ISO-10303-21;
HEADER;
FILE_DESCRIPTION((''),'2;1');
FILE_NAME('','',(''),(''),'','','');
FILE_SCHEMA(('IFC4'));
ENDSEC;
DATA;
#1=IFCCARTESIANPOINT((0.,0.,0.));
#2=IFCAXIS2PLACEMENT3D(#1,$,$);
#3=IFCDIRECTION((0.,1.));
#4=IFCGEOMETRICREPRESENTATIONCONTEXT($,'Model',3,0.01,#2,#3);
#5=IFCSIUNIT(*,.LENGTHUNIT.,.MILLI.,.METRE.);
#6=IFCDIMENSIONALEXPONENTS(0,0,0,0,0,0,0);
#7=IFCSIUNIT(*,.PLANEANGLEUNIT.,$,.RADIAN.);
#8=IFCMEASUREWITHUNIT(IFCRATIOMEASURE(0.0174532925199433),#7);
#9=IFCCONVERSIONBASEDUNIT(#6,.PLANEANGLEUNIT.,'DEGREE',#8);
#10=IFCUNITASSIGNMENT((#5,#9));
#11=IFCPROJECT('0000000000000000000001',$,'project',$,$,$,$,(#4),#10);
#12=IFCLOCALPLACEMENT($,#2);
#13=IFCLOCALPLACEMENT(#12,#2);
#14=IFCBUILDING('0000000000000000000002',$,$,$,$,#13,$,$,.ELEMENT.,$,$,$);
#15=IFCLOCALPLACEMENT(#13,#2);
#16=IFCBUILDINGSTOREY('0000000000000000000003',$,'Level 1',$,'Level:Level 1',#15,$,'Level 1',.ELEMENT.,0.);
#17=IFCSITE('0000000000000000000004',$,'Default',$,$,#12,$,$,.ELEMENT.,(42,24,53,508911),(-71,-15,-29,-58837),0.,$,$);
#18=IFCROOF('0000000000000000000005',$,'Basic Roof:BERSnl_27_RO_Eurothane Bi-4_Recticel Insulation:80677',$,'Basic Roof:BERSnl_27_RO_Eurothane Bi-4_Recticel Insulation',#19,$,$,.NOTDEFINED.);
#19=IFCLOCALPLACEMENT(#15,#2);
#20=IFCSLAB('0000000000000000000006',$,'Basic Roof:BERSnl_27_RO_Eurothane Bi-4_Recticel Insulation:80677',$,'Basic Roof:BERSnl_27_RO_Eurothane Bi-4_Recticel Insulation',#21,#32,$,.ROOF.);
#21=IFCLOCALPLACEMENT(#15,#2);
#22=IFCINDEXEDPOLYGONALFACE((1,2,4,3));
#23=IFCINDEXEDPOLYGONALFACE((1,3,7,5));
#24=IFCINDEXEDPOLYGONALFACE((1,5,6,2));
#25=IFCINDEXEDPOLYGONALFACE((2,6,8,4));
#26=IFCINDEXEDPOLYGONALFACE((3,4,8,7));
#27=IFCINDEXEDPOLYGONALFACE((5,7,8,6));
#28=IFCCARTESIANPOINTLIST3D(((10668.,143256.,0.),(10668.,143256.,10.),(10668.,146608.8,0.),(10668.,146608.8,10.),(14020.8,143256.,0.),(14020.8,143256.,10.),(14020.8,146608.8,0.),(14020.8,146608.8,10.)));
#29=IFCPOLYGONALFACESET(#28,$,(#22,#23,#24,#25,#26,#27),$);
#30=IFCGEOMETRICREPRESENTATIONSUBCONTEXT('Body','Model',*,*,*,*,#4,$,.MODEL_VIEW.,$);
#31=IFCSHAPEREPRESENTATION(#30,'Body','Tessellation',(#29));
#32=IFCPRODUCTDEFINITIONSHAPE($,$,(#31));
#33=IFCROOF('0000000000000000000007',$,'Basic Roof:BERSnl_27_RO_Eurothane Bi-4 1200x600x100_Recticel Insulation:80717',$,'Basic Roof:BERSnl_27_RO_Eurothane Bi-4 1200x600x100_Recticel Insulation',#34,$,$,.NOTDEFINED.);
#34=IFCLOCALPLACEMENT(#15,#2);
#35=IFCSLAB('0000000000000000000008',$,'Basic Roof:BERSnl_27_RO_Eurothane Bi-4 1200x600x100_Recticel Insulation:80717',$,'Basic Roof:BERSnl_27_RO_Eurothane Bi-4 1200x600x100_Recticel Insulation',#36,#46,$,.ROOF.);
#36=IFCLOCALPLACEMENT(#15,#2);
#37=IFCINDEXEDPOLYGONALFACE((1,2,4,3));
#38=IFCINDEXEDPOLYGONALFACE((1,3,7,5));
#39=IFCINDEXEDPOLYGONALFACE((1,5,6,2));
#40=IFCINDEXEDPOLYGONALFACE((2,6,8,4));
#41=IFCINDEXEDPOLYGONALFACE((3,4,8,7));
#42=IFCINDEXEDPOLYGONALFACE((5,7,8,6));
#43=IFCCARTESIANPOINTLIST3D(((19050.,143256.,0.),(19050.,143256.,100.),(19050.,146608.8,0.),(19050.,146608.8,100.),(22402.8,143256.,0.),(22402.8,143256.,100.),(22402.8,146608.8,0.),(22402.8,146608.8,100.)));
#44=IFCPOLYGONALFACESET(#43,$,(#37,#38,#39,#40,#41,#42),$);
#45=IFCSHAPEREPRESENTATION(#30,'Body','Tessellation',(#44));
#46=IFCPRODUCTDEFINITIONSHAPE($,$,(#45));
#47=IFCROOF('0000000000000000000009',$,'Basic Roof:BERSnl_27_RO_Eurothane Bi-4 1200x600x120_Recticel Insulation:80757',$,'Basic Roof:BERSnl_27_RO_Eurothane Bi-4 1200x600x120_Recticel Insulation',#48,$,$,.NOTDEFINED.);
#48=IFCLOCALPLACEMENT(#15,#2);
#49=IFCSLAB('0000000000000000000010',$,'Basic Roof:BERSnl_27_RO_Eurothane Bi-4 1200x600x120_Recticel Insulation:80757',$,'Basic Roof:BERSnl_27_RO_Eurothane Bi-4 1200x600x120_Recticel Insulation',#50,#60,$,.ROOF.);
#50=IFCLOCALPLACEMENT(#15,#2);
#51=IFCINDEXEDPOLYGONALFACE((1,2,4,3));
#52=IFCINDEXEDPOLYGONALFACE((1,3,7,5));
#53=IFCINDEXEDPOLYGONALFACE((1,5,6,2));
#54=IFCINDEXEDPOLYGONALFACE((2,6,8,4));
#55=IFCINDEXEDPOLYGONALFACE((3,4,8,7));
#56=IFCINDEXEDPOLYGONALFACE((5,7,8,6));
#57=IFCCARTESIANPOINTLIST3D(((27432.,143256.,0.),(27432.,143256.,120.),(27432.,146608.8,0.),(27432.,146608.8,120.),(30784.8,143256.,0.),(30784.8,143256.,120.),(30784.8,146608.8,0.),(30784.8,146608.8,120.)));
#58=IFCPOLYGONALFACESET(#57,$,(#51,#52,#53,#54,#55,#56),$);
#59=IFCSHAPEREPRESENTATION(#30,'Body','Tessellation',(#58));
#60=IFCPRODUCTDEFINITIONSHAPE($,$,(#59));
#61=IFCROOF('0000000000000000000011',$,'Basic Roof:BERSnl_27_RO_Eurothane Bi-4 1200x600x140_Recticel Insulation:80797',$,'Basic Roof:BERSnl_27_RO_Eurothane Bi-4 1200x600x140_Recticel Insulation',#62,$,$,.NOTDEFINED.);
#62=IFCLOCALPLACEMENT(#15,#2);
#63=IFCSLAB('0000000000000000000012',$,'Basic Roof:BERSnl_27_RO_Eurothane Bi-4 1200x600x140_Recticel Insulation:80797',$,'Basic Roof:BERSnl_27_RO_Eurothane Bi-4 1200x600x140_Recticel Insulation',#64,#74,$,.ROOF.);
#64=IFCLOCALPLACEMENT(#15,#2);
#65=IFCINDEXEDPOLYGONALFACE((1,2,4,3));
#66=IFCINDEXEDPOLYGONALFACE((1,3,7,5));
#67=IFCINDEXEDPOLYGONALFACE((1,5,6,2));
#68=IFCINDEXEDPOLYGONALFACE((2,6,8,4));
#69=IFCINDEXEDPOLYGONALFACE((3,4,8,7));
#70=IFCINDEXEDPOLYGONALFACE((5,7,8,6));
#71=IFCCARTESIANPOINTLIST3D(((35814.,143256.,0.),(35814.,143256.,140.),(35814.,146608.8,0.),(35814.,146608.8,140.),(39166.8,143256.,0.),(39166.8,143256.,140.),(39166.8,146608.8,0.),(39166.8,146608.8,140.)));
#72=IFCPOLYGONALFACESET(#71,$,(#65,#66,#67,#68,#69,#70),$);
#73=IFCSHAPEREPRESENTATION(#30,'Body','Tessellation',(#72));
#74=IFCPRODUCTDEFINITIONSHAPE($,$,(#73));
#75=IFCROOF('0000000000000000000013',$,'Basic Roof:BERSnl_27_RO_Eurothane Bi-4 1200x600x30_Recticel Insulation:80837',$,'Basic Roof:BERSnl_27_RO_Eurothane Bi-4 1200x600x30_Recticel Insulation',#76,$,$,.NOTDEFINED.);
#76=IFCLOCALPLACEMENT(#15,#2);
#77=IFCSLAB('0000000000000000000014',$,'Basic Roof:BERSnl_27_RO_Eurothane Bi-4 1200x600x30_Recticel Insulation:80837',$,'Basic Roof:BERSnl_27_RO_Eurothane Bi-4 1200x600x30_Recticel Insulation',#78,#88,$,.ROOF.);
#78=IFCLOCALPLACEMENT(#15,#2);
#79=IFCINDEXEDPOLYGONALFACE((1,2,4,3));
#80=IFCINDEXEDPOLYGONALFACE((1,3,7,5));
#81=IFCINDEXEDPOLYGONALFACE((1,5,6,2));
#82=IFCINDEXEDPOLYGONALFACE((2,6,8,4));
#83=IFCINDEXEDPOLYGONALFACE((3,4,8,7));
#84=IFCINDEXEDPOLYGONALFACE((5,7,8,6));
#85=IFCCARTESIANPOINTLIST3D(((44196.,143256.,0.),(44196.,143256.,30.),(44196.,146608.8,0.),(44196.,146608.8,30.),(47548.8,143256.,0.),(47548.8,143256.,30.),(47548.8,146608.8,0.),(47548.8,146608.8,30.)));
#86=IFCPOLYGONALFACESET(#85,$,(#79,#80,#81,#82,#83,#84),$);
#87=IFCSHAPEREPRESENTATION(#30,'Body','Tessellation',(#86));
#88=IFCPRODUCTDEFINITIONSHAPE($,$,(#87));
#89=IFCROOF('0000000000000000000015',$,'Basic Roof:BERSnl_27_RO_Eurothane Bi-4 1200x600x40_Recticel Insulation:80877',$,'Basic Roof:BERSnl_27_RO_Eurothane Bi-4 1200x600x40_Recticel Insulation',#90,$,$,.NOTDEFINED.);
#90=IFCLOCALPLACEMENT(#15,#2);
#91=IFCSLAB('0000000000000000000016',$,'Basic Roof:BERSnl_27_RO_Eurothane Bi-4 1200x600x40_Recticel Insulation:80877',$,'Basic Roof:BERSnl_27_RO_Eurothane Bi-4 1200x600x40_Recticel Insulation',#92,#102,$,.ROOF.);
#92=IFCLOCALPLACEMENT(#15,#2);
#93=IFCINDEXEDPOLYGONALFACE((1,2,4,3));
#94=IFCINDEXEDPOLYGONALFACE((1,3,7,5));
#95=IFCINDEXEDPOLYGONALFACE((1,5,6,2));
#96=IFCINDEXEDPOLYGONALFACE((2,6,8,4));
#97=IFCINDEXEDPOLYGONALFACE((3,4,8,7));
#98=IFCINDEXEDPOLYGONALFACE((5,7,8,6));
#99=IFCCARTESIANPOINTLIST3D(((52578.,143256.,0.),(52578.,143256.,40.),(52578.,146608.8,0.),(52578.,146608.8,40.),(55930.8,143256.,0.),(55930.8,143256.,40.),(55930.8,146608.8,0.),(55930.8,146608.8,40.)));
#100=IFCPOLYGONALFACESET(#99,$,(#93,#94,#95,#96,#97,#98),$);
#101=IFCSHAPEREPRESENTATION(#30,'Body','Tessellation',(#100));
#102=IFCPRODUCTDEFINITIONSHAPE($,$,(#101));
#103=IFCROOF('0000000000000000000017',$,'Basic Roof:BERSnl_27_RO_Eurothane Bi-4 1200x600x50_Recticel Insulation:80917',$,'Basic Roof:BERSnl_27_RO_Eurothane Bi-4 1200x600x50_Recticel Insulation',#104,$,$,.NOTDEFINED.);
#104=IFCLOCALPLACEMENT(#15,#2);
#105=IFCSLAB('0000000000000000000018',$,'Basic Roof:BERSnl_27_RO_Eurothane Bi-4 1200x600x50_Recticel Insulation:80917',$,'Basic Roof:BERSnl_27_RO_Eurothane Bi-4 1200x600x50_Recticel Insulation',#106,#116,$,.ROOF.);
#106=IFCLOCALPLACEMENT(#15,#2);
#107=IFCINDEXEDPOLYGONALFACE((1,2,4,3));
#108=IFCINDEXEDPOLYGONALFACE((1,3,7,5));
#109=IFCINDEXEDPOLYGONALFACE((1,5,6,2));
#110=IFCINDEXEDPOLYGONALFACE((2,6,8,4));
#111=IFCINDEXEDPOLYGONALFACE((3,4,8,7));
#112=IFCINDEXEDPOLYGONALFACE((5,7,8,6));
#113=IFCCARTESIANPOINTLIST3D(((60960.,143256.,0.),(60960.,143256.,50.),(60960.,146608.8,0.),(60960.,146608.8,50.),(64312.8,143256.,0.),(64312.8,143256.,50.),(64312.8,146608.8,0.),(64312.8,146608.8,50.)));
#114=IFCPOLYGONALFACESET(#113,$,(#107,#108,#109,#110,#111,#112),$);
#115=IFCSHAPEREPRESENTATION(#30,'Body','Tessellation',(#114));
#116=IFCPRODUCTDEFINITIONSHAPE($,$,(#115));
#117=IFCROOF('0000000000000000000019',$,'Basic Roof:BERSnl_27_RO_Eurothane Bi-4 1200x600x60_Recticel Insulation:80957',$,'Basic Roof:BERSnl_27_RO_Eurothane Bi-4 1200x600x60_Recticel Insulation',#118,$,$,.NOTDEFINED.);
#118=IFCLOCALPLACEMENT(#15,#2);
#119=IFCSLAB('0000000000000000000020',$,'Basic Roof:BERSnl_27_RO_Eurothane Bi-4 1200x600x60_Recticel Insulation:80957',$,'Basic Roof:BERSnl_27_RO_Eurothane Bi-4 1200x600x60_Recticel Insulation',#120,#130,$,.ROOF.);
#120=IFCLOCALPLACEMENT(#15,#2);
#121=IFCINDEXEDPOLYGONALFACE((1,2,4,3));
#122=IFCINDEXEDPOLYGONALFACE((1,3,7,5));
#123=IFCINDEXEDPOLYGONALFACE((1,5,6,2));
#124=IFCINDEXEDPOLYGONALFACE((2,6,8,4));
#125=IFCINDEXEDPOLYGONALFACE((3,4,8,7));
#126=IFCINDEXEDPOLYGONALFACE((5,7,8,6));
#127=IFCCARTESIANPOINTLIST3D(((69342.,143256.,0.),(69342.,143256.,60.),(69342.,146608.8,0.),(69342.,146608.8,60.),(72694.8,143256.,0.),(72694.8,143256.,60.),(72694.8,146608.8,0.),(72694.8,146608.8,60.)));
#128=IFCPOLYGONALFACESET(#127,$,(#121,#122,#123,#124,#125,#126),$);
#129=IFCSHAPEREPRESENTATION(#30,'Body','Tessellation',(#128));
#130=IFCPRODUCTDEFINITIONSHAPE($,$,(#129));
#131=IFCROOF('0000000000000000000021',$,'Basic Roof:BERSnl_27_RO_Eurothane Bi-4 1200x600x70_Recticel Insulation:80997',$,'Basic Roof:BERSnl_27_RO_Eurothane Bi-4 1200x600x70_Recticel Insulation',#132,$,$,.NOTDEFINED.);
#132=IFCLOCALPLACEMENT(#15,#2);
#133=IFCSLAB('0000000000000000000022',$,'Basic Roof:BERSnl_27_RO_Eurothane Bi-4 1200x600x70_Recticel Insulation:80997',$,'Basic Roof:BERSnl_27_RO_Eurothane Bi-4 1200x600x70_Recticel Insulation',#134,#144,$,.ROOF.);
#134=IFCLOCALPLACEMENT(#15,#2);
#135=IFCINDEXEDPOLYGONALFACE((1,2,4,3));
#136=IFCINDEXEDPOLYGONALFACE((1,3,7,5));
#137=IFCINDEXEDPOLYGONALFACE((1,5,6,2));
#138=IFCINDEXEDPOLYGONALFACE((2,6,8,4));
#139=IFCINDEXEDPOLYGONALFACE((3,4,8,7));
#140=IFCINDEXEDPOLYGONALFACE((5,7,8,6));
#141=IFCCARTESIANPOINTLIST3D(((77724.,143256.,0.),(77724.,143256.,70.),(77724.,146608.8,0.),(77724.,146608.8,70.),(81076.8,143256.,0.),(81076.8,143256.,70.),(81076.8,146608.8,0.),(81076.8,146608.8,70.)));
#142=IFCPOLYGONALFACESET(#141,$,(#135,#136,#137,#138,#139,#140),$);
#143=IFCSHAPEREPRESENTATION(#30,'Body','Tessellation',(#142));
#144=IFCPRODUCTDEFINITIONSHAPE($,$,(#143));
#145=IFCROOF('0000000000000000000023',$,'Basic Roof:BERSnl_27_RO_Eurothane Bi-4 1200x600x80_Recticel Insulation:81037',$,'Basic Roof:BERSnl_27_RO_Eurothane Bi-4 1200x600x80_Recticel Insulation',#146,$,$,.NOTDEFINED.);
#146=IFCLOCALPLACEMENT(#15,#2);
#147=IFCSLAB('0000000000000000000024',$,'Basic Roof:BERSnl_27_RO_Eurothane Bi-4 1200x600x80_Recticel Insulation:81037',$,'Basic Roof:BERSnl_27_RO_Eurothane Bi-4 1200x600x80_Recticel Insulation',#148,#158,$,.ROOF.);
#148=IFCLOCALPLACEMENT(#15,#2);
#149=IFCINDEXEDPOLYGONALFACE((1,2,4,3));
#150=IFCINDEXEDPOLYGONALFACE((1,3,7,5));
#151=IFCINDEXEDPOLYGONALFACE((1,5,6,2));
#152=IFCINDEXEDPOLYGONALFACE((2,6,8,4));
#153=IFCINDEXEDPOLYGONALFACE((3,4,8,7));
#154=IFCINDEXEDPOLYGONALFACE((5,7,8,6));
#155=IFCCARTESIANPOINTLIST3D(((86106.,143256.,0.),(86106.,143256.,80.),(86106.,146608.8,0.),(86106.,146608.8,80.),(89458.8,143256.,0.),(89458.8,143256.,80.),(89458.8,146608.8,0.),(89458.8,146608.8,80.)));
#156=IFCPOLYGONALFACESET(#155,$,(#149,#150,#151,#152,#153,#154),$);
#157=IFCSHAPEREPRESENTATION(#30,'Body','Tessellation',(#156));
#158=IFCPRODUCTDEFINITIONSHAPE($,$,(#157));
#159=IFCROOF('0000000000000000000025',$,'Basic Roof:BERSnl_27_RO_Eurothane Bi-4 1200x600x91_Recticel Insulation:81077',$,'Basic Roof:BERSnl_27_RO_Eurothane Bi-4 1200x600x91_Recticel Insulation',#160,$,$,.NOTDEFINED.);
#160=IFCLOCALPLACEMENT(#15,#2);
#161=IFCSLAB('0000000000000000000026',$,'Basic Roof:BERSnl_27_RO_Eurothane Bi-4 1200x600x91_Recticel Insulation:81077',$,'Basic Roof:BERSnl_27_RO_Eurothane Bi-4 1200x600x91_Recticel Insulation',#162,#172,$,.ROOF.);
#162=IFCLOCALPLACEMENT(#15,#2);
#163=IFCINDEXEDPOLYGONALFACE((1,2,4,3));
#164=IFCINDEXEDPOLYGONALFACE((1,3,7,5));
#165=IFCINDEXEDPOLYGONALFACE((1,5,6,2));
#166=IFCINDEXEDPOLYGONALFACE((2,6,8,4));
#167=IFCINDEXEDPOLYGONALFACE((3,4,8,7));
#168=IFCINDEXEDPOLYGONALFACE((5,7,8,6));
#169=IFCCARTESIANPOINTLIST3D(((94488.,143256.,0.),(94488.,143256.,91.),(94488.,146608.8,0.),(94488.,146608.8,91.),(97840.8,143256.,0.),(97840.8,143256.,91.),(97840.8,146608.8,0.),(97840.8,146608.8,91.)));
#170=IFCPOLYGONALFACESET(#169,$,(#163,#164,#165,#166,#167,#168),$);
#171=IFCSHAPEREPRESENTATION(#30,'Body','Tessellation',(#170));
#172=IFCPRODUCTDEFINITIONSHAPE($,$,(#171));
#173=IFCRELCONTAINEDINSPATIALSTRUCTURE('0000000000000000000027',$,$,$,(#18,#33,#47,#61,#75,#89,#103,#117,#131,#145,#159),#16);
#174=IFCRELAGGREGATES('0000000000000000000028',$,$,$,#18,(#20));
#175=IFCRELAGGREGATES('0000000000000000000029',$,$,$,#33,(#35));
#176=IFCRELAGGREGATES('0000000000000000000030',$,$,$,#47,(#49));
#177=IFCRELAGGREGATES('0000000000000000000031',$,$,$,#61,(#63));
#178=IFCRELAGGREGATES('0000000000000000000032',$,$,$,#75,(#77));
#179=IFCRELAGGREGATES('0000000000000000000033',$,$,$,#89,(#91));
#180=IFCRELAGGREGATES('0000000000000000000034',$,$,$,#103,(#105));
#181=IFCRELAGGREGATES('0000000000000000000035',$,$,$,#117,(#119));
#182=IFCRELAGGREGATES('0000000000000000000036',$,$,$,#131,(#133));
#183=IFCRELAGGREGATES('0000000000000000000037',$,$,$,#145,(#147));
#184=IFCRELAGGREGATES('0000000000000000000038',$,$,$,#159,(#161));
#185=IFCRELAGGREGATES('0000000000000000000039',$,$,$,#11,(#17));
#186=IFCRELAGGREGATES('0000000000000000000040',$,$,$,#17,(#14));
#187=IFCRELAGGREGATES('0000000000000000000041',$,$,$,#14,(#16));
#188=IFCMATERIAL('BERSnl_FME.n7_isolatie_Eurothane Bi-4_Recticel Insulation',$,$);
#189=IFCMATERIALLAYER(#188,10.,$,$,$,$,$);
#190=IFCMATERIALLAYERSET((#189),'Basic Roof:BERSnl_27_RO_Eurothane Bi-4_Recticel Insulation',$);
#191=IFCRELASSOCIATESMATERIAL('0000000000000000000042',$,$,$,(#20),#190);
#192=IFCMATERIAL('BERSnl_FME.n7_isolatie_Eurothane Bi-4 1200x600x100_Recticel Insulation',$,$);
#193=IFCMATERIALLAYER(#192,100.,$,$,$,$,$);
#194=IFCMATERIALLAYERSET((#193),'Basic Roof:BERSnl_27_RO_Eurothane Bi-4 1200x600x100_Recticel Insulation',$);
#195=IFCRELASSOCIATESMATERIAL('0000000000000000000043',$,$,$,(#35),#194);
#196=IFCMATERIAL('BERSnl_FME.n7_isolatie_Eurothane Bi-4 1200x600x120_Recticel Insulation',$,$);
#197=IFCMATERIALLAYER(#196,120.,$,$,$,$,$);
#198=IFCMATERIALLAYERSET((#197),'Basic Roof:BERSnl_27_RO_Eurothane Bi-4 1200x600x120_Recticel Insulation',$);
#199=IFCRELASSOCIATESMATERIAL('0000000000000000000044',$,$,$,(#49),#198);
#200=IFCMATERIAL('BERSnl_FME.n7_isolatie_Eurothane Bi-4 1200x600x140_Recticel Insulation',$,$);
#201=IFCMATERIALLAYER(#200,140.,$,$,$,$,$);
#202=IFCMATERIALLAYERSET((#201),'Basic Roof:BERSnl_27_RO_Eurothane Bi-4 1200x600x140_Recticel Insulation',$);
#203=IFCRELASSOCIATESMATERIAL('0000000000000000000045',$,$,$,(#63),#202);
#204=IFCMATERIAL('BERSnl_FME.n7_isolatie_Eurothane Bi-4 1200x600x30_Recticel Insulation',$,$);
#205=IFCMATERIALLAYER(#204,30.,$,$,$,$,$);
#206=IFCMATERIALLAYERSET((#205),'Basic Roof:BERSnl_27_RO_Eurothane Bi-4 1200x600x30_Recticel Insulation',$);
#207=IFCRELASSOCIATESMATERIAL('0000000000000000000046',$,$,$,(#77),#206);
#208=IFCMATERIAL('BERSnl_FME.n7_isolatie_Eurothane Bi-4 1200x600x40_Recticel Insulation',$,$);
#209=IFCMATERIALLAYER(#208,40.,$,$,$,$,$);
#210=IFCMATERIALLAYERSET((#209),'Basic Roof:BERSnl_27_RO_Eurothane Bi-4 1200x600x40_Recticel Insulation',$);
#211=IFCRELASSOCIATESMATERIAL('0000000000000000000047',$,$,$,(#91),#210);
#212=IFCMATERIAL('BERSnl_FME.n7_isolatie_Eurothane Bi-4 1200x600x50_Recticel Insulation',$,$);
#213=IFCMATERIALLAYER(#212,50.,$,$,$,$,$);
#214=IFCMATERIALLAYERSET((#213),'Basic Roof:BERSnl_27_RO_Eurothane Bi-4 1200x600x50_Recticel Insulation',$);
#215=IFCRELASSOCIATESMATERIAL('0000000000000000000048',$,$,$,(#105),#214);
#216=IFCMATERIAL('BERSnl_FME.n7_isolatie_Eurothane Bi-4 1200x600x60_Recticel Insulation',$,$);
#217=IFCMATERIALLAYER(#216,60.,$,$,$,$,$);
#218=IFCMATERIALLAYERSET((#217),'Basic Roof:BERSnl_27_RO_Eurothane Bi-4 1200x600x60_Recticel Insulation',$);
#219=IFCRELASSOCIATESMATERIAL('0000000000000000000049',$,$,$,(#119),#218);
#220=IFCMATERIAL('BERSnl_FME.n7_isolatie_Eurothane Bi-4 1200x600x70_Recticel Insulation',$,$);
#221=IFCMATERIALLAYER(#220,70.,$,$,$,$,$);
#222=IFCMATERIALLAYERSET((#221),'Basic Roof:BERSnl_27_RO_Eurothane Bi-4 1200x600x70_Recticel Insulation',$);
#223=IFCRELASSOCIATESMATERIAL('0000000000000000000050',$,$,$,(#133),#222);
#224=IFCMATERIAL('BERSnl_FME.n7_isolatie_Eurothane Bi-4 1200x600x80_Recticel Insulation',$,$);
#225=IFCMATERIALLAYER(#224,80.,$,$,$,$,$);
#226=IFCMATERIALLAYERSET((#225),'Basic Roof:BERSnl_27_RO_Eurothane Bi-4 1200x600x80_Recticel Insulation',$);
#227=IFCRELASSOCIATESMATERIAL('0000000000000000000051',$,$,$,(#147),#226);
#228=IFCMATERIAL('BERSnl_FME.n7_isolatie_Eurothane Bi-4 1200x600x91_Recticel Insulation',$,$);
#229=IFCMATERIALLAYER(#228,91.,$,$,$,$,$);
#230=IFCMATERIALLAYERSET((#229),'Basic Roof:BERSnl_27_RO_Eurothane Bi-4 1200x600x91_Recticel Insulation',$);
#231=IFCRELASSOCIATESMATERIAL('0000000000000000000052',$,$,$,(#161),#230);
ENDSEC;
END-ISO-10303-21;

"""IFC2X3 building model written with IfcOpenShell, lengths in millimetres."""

from ifc_helpers import new_model, entity, si_unit, converted_unit, direction, frame, frame_2d, origin, place, context, subcontext, project, spatial, rectangle, extrude, material, layer, layer_set, element, aggregate, save


model = new_model("IFC2X3")

# Units and contexts
model_context = context("Model", 3, precision=0.01, world=origin(), true_north=direction((0.0, 1.0)))
body_context = subcontext(model_context, "Body", "Model", "MODEL_VIEW")
ifc_project = project(units=[si_unit("LENGTHUNIT", "METRE", prefix="MILLI"), converted_unit("PLANEANGLEUNIT", "DEGREE", entity("IfcRatioMeasure", 0.0174532925199433), si_unit("PLANEANGLEUNIT", "RADIAN"), dimensions=[0, 0, 0, 0, 0, 0, 0])], contexts=[model_context])

# Site, building, storey
site_placement = place(None, origin())
site = spatial("IfcSite", under=ifc_project, at=site_placement, Name="Default", CompositionType="ELEMENT", RefLatitude=(42, 24, 53, 508911), RefLongitude=(-71, -15, -29, -58837), RefElevation=0.0)
building_placement = place(site_placement, origin())
building = spatial("IfcBuilding", under=site, at=building_placement, CompositionType="ELEMENT")
storey_placement = place(building_placement, origin())
storey = spatial("IfcBuildingStorey", under=building, at=storey_placement, Name="Level 1", ObjectType="Level:Level 1", LongName="Level 1", CompositionType="ELEMENT", Elevation=0.0)

# Roofs, slabs
roof_1_placement = place(storey_placement, frame((10668.0, 143256.0, 0.0)))
roof_1 = element("IfcRoof", 1, at=roof_1_placement, inside=storey, Name="Basic Roof:BERSnl_27_RO_Eurothane Bi-4_Recticel Insulation:80677", ObjectType="Basic Roof:BERSnl_27_RO_Eurothane Bi-4_Recticel Insulation", ShapeType="NOTDEFINED")
ifc_material_1 = material(Name="BERSnl_FME.n7_isolatie_Eurothane Bi-4_Recticel Insulation")
ifc_layer_1 = layer(ifc_material_1, 10.0)
ifc_layer_set_1 = layer_set([ifc_layer_1], Name="Basic Roof:BERSnl_27_RO_Eurothane Bi-4_Recticel Insulation")
slab_1_placement = place(roof_1_placement, origin())
slab_1 = element("IfcSlab", 2, at=slab_1_placement, material=ifc_layer_set_1, Name="Basic Roof:BERSnl_27_RO_Eurothane Bi-4_Recticel Insulation:80677", ObjectType="Basic Roof:BERSnl_27_RO_Eurothane Bi-4_Recticel Insulation", PredefinedType="ROOF", context=body_context, shape_type="SweptSolid", body=[
    extrude(rectangle(XDim=3352.8, YDim=3352.8, at=frame_2d((0.0, 0.0), x_axis=(-1.0, 0.0))), frame((1676.4, 1676.4, 0.0)), (0.0, 0.0, 1.0), 10.0),
])
aggregate(roof_1, [slab_1])
roof_2_placement = place(storey_placement, frame((19050.0, 143256.0, 0.0)))
roof_2 = element("IfcRoof", 3, at=roof_2_placement, inside=storey, Name="Basic Roof:BERSnl_27_RO_Eurothane Bi-4 1200x600x100_Recticel Insulation:80717", ObjectType="Basic Roof:BERSnl_27_RO_Eurothane Bi-4 1200x600x100_Recticel Insulation", ShapeType="NOTDEFINED")
ifc_material_2 = material(Name="BERSnl_FME.n7_isolatie_Eurothane Bi-4 1200x600x100_Recticel Insulation")
ifc_layer_2 = layer(ifc_material_2, 100.0)
ifc_layer_set_2 = layer_set([ifc_layer_2], Name="Basic Roof:BERSnl_27_RO_Eurothane Bi-4 1200x600x100_Recticel Insulation")
slab_2_placement = place(roof_2_placement, origin())
slab_2 = element("IfcSlab", 4, at=slab_2_placement, material=ifc_layer_set_2, Name="Basic Roof:BERSnl_27_RO_Eurothane Bi-4 1200x600x100_Recticel Insulation:80717", ObjectType="Basic Roof:BERSnl_27_RO_Eurothane Bi-4 1200x600x100_Recticel Insulation", PredefinedType="ROOF", context=body_context, shape_type="SweptSolid", body=[
    extrude(rectangle(XDim=3352.8, YDim=3352.8, at=frame_2d((0.0, 0.0), x_axis=(-1.0, 0.0))), frame((1676.4, 1676.4, 0.0)), (0.0, 0.0, 1.0), 100.0),
])
aggregate(roof_2, [slab_2])
roof_3_placement = place(storey_placement, frame((27432.0, 143256.0, 0.0)))
roof_3 = element("IfcRoof", 5, at=roof_3_placement, inside=storey, Name="Basic Roof:BERSnl_27_RO_Eurothane Bi-4 1200x600x120_Recticel Insulation:80757", ObjectType="Basic Roof:BERSnl_27_RO_Eurothane Bi-4 1200x600x120_Recticel Insulation", ShapeType="NOTDEFINED")
ifc_material_3 = material(Name="BERSnl_FME.n7_isolatie_Eurothane Bi-4 1200x600x120_Recticel Insulation")
ifc_layer_3 = layer(ifc_material_3, 120.0)
ifc_layer_set_3 = layer_set([ifc_layer_3], Name="Basic Roof:BERSnl_27_RO_Eurothane Bi-4 1200x600x120_Recticel Insulation")
slab_3_placement = place(roof_3_placement, origin())
slab_3 = element("IfcSlab", 6, at=slab_3_placement, material=ifc_layer_set_3, Name="Basic Roof:BERSnl_27_RO_Eurothane Bi-4 1200x600x120_Recticel Insulation:80757", ObjectType="Basic Roof:BERSnl_27_RO_Eurothane Bi-4 1200x600x120_Recticel Insulation", PredefinedType="ROOF", context=body_context, shape_type="SweptSolid", body=[
    extrude(rectangle(XDim=3352.8, YDim=3352.8, at=frame_2d((0.0, 0.0), x_axis=(-1.0, 0.0))), frame((1676.4, 1676.4, 0.0)), (0.0, 0.0, 1.0), 120.0),
])
aggregate(roof_3, [slab_3])
roof_4_placement = place(storey_placement, frame((35814.0, 143256.0, 0.0)))
roof_4 = element("IfcRoof", 7, at=roof_4_placement, inside=storey, Name="Basic Roof:BERSnl_27_RO_Eurothane Bi-4 1200x600x140_Recticel Insulation:80797", ObjectType="Basic Roof:BERSnl_27_RO_Eurothane Bi-4 1200x600x140_Recticel Insulation", ShapeType="NOTDEFINED")
ifc_material_4 = material(Name="BERSnl_FME.n7_isolatie_Eurothane Bi-4 1200x600x140_Recticel Insulation")
ifc_layer_4 = layer(ifc_material_4, 140.0)
ifc_layer_set_4 = layer_set([ifc_layer_4], Name="Basic Roof:BERSnl_27_RO_Eurothane Bi-4 1200x600x140_Recticel Insulation")
slab_4_placement = place(roof_4_placement, origin())
slab_4 = element("IfcSlab", 8, at=slab_4_placement, material=ifc_layer_set_4, Name="Basic Roof:BERSnl_27_RO_Eurothane Bi-4 1200x600x140_Recticel Insulation:80797", ObjectType="Basic Roof:BERSnl_27_RO_Eurothane Bi-4 1200x600x140_Recticel Insulation", PredefinedType="ROOF", context=body_context, shape_type="SweptSolid", body=[
    extrude(rectangle(XDim=3352.8, YDim=3352.8, at=frame_2d((0.0, 0.0), x_axis=(-1.0, 0.0))), frame((1676.4, 1676.4, 0.0)), (0.0, 0.0, 1.0), 140.0),
])
aggregate(roof_4, [slab_4])
roof_5_placement = place(storey_placement, frame((44196.0, 143256.0, 0.0)))
roof_5 = element("IfcRoof", 9, at=roof_5_placement, inside=storey, Name="Basic Roof:BERSnl_27_RO_Eurothane Bi-4 1200x600x30_Recticel Insulation:80837", ObjectType="Basic Roof:BERSnl_27_RO_Eurothane Bi-4 1200x600x30_Recticel Insulation", ShapeType="NOTDEFINED")
ifc_material_5 = material(Name="BERSnl_FME.n7_isolatie_Eurothane Bi-4 1200x600x30_Recticel Insulation")
ifc_layer_5 = layer(ifc_material_5, 30.0)
ifc_layer_set_5 = layer_set([ifc_layer_5], Name="Basic Roof:BERSnl_27_RO_Eurothane Bi-4 1200x600x30_Recticel Insulation")
slab_5_placement = place(roof_5_placement, origin())
slab_5 = element("IfcSlab", 10, at=slab_5_placement, material=ifc_layer_set_5, Name="Basic Roof:BERSnl_27_RO_Eurothane Bi-4 1200x600x30_Recticel Insulation:80837", ObjectType="Basic Roof:BERSnl_27_RO_Eurothane Bi-4 1200x600x30_Recticel Insulation", PredefinedType="ROOF", context=body_context, shape_type="SweptSolid", body=[
    extrude(rectangle(XDim=3352.8, YDim=3352.8, at=frame_2d((0.0, 0.0), x_axis=(-1.0, 0.0))), frame((1676.4, 1676.4, 0.0)), (0.0, 0.0, 1.0), 30.0),
])
aggregate(roof_5, [slab_5])
roof_6_placement = place(storey_placement, frame((52578.0, 143256.0, 0.0)))
roof_6 = element("IfcRoof", 11, at=roof_6_placement, inside=storey, Name="Basic Roof:BERSnl_27_RO_Eurothane Bi-4 1200x600x40_Recticel Insulation:80877", ObjectType="Basic Roof:BERSnl_27_RO_Eurothane Bi-4 1200x600x40_Recticel Insulation", ShapeType="NOTDEFINED")
ifc_material_6 = material(Name="BERSnl_FME.n7_isolatie_Eurothane Bi-4 1200x600x40_Recticel Insulation")
ifc_layer_6 = layer(ifc_material_6, 40.0)
ifc_layer_set_6 = layer_set([ifc_layer_6], Name="Basic Roof:BERSnl_27_RO_Eurothane Bi-4 1200x600x40_Recticel Insulation")
slab_6_placement = place(roof_6_placement, origin())
slab_6 = element("IfcSlab", 12, at=slab_6_placement, material=ifc_layer_set_6, Name="Basic Roof:BERSnl_27_RO_Eurothane Bi-4 1200x600x40_Recticel Insulation:80877", ObjectType="Basic Roof:BERSnl_27_RO_Eurothane Bi-4 1200x600x40_Recticel Insulation", PredefinedType="ROOF", context=body_context, shape_type="SweptSolid", body=[
    extrude(rectangle(XDim=3352.8, YDim=3352.8, at=frame_2d((0.0, 0.0), x_axis=(-1.0, 0.0))), frame((1676.4, 1676.4, 0.0)), (0.0, 0.0, 1.0), 40.0),
])
aggregate(roof_6, [slab_6])
roof_7_placement = place(storey_placement, frame((60960.0, 143256.0, 0.0)))
roof_7 = element("IfcRoof", 13, at=roof_7_placement, inside=storey, Name="Basic Roof:BERSnl_27_RO_Eurothane Bi-4 1200x600x50_Recticel Insulation:80917", ObjectType="Basic Roof:BERSnl_27_RO_Eurothane Bi-4 1200x600x50_Recticel Insulation", ShapeType="NOTDEFINED")
ifc_material_7 = material(Name="BERSnl_FME.n7_isolatie_Eurothane Bi-4 1200x600x50_Recticel Insulation")
ifc_layer_7 = layer(ifc_material_7, 50.0)
ifc_layer_set_7 = layer_set([ifc_layer_7], Name="Basic Roof:BERSnl_27_RO_Eurothane Bi-4 1200x600x50_Recticel Insulation")
slab_7_placement = place(roof_7_placement, origin())
slab_7 = element("IfcSlab", 14, at=slab_7_placement, material=ifc_layer_set_7, Name="Basic Roof:BERSnl_27_RO_Eurothane Bi-4 1200x600x50_Recticel Insulation:80917", ObjectType="Basic Roof:BERSnl_27_RO_Eurothane Bi-4 1200x600x50_Recticel Insulation", PredefinedType="ROOF", context=body_context, shape_type="SweptSolid", body=[
    extrude(rectangle(XDim=3352.8, YDim=3352.8, at=frame_2d((0.0, 0.0), x_axis=(-1.0, 0.0))), frame((1676.4, 1676.4, 0.0)), (0.0, 0.0, 1.0), 50.0),
])
aggregate(roof_7, [slab_7])
roof_8_placement = place(storey_placement, frame((69342.0, 143256.0, 0.0)))
roof_8 = element("IfcRoof", 15, at=roof_8_placement, inside=storey, Name="Basic Roof:BERSnl_27_RO_Eurothane Bi-4 1200x600x60_Recticel Insulation:80957", ObjectType="Basic Roof:BERSnl_27_RO_Eurothane Bi-4 1200x600x60_Recticel Insulation", ShapeType="NOTDEFINED")
ifc_material_8 = material(Name="BERSnl_FME.n7_isolatie_Eurothane Bi-4 1200x600x60_Recticel Insulation")
ifc_layer_8 = layer(ifc_material_8, 60.0)
ifc_layer_set_8 = layer_set([ifc_layer_8], Name="Basic Roof:BERSnl_27_RO_Eurothane Bi-4 1200x600x60_Recticel Insulation")
slab_8_placement = place(roof_8_placement, origin())
slab_8 = element("IfcSlab", 16, at=slab_8_placement, material=ifc_layer_set_8, Name="Basic Roof:BERSnl_27_RO_Eurothane Bi-4 1200x600x60_Recticel Insulation:80957", ObjectType="Basic Roof:BERSnl_27_RO_Eurothane Bi-4 1200x600x60_Recticel Insulation", PredefinedType="ROOF", context=body_context, shape_type="SweptSolid", body=[
    extrude(rectangle(XDim=3352.8, YDim=3352.8, at=frame_2d((0.0, 0.0), x_axis=(-1.0, 0.0))), frame((1676.4, 1676.4, 0.0)), (0.0, 0.0, 1.0), 60.0),
])
aggregate(roof_8, [slab_8])
roof_9_placement = place(storey_placement, frame((77724.0, 143256.0, 0.0)))
roof_9 = element("IfcRoof", 17, at=roof_9_placement, inside=storey, Name="Basic Roof:BERSnl_27_RO_Eurothane Bi-4 1200x600x70_Recticel Insulation:80997", ObjectType="Basic Roof:BERSnl_27_RO_Eurothane Bi-4 1200x600x70_Recticel Insulation", ShapeType="NOTDEFINED")
ifc_material_9 = material(Name="BERSnl_FME.n7_isolatie_Eurothane Bi-4 1200x600x70_Recticel Insulation")
ifc_layer_9 = layer(ifc_material_9, 70.0)
ifc_layer_set_9 = layer_set([ifc_layer_9], Name="Basic Roof:BERSnl_27_RO_Eurothane Bi-4 1200x600x70_Recticel Insulation")
slab_9_placement = place(roof_9_placement, origin())
slab_9 = element("IfcSlab", 18, at=slab_9_placement, material=ifc_layer_set_9, Name="Basic Roof:BERSnl_27_RO_Eurothane Bi-4 1200x600x70_Recticel Insulation:80997", ObjectType="Basic Roof:BERSnl_27_RO_Eurothane Bi-4 1200x600x70_Recticel Insulation", PredefinedType="ROOF", context=body_context, shape_type="SweptSolid", body=[
    extrude(rectangle(XDim=3352.8, YDim=3352.8, at=frame_2d((0.0, 0.0), x_axis=(-1.0, 0.0))), frame((1676.4, 1676.4, 0.0)), (0.0, 0.0, 1.0), 70.0),
])
aggregate(roof_9, [slab_9])
roof_10_placement = place(storey_placement, frame((86106.0, 143256.0, 0.0)))
roof_10 = element("IfcRoof", 19, at=roof_10_placement, inside=storey, Name="Basic Roof:BERSnl_27_RO_Eurothane Bi-4 1200x600x80_Recticel Insulation:81037", ObjectType="Basic Roof:BERSnl_27_RO_Eurothane Bi-4 1200x600x80_Recticel Insulation", ShapeType="NOTDEFINED")
ifc_material_10 = material(Name="BERSnl_FME.n7_isolatie_Eurothane Bi-4 1200x600x80_Recticel Insulation")
ifc_layer_10 = layer(ifc_material_10, 80.0)
ifc_layer_set_10 = layer_set([ifc_layer_10], Name="Basic Roof:BERSnl_27_RO_Eurothane Bi-4 1200x600x80_Recticel Insulation")
slab_10_placement = place(roof_10_placement, origin())
slab_10 = element("IfcSlab", 20, at=slab_10_placement, material=ifc_layer_set_10, Name="Basic Roof:BERSnl_27_RO_Eurothane Bi-4 1200x600x80_Recticel Insulation:81037", ObjectType="Basic Roof:BERSnl_27_RO_Eurothane Bi-4 1200x600x80_Recticel Insulation", PredefinedType="ROOF", context=body_context, shape_type="SweptSolid", body=[
    extrude(rectangle(XDim=3352.8, YDim=3352.8, at=frame_2d((0.0, 0.0), x_axis=(-1.0, 0.0))), frame((1676.4, 1676.4, 0.0)), (0.0, 0.0, 1.0), 80.0),
])
aggregate(roof_10, [slab_10])
roof_11_placement = place(storey_placement, frame((94488.0, 143256.0, 0.0)))
roof_11 = element("IfcRoof", 21, at=roof_11_placement, inside=storey, Name="Basic Roof:BERSnl_27_RO_Eurothane Bi-4 1200x600x91_Recticel Insulation:81077", ObjectType="Basic Roof:BERSnl_27_RO_Eurothane Bi-4 1200x600x91_Recticel Insulation", ShapeType="NOTDEFINED")
ifc_material_11 = material(Name="BERSnl_FME.n7_isolatie_Eurothane Bi-4 1200x600x91_Recticel Insulation")
ifc_layer_11 = layer(ifc_material_11, 91.0)
ifc_layer_set_11 = layer_set([ifc_layer_11], Name="Basic Roof:BERSnl_27_RO_Eurothane Bi-4 1200x600x91_Recticel Insulation")
slab_11_placement = place(roof_11_placement, origin())
slab_11 = element("IfcSlab", 22, at=slab_11_placement, material=ifc_layer_set_11, Name="Basic Roof:BERSnl_27_RO_Eurothane Bi-4 1200x600x91_Recticel Insulation:81077", ObjectType="Basic Roof:BERSnl_27_RO_Eurothane Bi-4 1200x600x91_Recticel Insulation", PredefinedType="ROOF", context=body_context, shape_type="SweptSolid", body=[
    extrude(rectangle(XDim=3352.8, YDim=3352.8, at=frame_2d((0.0, 0.0), x_axis=(-1.0, 0.0))), frame((1676.4, 1676.4, 0.0)), (0.0, 0.0, 1.0), 91.0),
])
aggregate(roof_11, [slab_11])

save(model, "model.ifc")
